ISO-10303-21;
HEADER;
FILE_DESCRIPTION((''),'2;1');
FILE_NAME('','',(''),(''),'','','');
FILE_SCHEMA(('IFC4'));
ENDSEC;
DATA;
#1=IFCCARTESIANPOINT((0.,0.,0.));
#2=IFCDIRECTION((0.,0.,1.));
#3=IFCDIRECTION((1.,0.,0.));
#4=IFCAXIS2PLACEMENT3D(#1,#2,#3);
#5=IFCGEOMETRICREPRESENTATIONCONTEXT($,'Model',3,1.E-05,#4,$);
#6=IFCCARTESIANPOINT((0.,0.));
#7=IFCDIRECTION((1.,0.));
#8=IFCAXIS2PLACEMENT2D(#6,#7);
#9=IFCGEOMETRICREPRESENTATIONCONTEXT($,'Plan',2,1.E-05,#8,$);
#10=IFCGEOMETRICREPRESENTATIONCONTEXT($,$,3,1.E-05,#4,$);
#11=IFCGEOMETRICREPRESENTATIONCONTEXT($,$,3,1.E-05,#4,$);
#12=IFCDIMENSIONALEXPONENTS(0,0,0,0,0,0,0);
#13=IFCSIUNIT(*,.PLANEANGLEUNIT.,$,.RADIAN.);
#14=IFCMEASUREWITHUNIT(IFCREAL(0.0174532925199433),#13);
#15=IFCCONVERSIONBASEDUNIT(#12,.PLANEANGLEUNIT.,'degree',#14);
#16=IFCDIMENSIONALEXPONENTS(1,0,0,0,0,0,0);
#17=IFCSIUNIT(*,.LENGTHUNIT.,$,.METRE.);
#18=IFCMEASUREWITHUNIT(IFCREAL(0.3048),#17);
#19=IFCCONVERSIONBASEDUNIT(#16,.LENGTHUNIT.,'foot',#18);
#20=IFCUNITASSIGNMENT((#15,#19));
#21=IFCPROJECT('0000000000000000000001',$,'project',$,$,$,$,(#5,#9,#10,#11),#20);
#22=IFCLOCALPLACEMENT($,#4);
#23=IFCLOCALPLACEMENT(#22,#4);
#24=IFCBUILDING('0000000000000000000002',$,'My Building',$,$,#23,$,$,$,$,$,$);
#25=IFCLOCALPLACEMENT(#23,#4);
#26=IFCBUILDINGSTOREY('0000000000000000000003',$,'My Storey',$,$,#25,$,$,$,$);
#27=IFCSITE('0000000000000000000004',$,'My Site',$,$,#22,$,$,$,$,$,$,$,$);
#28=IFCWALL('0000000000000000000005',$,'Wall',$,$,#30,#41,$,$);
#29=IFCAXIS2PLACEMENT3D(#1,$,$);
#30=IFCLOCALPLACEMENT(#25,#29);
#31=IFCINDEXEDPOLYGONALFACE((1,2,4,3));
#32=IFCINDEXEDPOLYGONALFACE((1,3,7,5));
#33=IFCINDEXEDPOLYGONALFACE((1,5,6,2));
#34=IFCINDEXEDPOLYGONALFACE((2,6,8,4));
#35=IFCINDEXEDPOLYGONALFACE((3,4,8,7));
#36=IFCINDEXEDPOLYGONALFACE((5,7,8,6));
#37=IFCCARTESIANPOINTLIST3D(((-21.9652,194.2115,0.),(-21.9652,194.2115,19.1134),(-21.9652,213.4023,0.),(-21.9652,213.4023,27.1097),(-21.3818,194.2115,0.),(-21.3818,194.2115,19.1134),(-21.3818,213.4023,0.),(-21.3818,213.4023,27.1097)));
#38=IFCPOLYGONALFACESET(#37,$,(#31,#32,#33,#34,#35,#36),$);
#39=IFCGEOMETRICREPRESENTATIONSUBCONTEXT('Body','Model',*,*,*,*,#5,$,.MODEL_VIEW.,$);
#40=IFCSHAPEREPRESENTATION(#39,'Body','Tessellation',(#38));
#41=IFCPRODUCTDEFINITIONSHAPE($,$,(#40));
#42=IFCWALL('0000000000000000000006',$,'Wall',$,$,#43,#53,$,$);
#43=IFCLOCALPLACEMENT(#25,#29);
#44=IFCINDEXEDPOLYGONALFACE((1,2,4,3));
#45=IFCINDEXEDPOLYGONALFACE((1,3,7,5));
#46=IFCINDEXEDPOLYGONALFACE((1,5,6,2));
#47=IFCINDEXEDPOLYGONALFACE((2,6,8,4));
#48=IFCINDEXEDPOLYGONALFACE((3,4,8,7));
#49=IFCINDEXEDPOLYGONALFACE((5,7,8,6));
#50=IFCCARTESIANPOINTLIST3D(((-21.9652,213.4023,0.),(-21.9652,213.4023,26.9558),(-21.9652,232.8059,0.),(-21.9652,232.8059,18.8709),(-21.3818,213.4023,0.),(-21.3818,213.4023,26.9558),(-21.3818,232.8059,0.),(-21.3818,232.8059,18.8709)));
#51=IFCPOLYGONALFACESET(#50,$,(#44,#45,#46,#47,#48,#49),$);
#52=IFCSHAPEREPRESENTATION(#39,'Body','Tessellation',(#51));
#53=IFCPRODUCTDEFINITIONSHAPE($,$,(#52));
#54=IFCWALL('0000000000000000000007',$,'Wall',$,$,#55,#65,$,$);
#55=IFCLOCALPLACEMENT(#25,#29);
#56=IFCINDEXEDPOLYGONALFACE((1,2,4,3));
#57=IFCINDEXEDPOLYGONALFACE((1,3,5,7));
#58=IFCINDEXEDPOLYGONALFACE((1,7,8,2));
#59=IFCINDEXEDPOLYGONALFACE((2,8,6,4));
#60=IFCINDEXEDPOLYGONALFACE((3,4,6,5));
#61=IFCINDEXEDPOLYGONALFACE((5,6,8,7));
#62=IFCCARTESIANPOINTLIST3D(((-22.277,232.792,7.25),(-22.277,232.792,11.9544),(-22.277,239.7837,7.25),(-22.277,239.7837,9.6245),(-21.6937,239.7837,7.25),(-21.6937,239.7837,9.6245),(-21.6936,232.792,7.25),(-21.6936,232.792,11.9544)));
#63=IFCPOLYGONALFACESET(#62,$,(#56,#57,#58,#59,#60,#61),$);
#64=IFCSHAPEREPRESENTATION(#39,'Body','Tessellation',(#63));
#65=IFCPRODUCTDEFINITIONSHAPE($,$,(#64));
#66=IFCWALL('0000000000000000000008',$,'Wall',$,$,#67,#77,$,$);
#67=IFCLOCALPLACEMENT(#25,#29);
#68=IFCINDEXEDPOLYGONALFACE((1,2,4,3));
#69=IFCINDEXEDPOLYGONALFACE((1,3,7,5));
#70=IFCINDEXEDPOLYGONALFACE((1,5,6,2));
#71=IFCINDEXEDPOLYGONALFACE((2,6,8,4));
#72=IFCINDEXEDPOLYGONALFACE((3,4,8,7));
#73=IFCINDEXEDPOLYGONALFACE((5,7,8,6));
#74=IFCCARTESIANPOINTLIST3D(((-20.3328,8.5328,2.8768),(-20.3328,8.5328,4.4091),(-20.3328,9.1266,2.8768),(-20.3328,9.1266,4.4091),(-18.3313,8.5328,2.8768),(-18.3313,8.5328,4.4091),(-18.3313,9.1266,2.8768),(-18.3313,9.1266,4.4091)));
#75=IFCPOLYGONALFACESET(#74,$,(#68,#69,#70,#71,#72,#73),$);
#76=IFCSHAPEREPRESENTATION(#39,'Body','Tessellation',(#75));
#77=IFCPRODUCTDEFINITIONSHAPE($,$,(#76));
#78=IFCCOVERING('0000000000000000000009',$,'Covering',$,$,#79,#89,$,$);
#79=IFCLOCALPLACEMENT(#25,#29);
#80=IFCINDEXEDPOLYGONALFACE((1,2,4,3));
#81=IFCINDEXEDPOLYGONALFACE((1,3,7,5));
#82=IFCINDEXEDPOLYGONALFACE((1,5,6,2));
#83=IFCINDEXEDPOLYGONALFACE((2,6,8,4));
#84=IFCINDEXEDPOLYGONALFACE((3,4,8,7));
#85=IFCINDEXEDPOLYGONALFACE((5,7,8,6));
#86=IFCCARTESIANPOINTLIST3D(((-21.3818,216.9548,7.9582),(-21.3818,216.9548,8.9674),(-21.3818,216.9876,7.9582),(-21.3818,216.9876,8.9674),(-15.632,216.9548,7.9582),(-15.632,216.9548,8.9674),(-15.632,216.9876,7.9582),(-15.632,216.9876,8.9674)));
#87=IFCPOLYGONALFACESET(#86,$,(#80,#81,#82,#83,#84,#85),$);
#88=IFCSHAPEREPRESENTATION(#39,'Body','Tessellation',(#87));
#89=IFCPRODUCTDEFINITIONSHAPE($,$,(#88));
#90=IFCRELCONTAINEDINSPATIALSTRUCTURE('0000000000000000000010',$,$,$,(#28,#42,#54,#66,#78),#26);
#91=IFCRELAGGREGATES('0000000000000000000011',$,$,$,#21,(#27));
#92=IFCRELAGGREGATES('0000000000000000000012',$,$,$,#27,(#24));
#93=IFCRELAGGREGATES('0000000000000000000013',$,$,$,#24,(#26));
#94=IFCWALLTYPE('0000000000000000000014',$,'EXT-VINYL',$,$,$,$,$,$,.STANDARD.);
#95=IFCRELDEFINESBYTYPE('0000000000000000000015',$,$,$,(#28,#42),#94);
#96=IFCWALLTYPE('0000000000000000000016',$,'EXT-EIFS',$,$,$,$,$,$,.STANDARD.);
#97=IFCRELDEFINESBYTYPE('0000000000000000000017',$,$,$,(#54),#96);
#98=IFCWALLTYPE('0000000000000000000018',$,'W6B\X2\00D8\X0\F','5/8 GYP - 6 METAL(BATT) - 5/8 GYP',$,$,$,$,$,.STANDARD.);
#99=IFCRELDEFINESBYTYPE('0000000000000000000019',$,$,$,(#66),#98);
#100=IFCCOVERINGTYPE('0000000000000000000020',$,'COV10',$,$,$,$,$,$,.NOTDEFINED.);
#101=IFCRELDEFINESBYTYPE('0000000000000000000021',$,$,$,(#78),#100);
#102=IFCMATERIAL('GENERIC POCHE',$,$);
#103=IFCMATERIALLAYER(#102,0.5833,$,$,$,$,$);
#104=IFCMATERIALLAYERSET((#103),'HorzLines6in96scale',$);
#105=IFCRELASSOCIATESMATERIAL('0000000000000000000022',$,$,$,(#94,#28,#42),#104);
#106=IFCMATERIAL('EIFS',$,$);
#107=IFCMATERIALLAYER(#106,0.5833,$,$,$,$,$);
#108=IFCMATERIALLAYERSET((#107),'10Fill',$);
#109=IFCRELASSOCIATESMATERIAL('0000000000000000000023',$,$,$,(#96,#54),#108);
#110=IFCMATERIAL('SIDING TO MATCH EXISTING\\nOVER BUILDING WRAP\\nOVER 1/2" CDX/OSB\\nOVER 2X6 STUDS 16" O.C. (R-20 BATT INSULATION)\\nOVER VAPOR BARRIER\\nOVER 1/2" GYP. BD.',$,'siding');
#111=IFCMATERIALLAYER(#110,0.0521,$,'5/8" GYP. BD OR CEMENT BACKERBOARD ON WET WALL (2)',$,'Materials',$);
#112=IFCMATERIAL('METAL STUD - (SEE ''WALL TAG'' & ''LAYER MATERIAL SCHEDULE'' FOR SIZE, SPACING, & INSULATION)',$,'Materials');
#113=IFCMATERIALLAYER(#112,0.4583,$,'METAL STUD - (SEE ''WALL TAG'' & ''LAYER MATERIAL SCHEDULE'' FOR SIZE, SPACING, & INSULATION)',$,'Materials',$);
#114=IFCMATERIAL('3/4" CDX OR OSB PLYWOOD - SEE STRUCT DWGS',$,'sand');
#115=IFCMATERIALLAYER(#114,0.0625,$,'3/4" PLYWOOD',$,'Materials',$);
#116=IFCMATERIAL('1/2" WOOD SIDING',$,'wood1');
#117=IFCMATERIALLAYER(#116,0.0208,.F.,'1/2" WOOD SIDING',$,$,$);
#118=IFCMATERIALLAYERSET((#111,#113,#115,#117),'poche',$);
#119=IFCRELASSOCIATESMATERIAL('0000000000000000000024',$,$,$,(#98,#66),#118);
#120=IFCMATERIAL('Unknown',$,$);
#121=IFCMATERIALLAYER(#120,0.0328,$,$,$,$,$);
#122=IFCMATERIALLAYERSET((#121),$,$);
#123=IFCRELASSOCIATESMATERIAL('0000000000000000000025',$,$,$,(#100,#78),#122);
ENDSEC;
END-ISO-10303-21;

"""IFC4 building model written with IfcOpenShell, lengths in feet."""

from ifc_helpers import new_model, entity, si_unit, converted_unit, frame, origin_with_axes, origin_2d_with_axis, place, context, subcontext, project, spatial, indexed_curve, outline, extrude, clip, halfspace, material, layer, layer_set, layer_usage, type_object, element, save


model = new_model("IFC4")

# Units and contexts
model_context = context("Model", 3, precision=1e-05, world=origin_with_axes())
plan_context = context("Plan", 2, precision=1e-05, world=origin_2d_with_axis())
context_of_model_1 = context(None, 3, precision=1e-05, world=origin_with_axes())
context_of_model_2 = context(None, 3, precision=1e-05, world=origin_with_axes())
body_context = subcontext(model_context, "Body", "Model", "MODEL_VIEW")
ifc_project = project(units=[converted_unit("PLANEANGLEUNIT", "degree", entity("IfcReal", 0.0174532925199433), si_unit("PLANEANGLEUNIT", "RADIAN"), dimensions=[0, 0, 0, 0, 0, 0, 0]), converted_unit("LENGTHUNIT", "foot", entity("IfcReal", 0.3048), si_unit("LENGTHUNIT", "METRE"), dimensions=[1, 0, 0, 0, 0, 0, 0])], contexts=[model_context, plan_context, context_of_model_1, context_of_model_2])

# Site, building, storey
site_placement = place(None, origin_with_axes())
site = spatial("IfcSite", under=ifc_project, at=site_placement, Name="My Site")
building_placement = place(site_placement, origin_with_axes())
building = spatial("IfcBuilding", under=site, at=building_placement, Name="My Building")
storey_placement = place(building_placement, origin_with_axes())
storey = spatial("IfcBuildingStorey", under=building, at=storey_placement, Name="My Storey")

# Walls
ifc_material_1 = material(Name="GENERIC POCHE")
ifc_layer_1 = layer(ifc_material_1, 0.5833)
ifc_layer_set_1 = layer_set([ifc_layer_1], Name="HorzLines6in96scale")
ifc_layer_usage_1 = layer_usage(ifc_layer_set_1, "AXIS2", "POSITIVE", 0.0)
wall_type_1 = type_object("IfcWallType", Name="EXT-VINYL", PredefinedType="STANDARD", material=ifc_layer_set_1)
wall_1_placement = place(storey_placement, frame((-21.3818, 194.2115, 0.0), z_axis=(0.0, 0.0, 1.0), x_axis=(0.0, 1.0, 0.0)))
element("IfcWall", 1, at=wall_1_placement, inside=storey, type_object=wall_type_1, material=ifc_layer_usage_1, Name="Wall", context=body_context, shape_type="Clipping", body=[
    clip(extrude(outline(indexed_curve([(0.0, 0.0), (0.0, 0.5833), (19.1908, 0.5833), (19.1908, 0.0), (0.0, 0.0)], self_intersect=False)), origin_with_axes(), (0.0, 0.0, 1.0), 27.1097), halfspace(frame((19.1908, 0.0, 27.1097), z_axis=(-0.384618, 0.0, 0.923076), x_axis=(0.0, -1.0, 0.0)), False)),
])
ifc_layer_usage_2 = layer_usage(ifc_layer_set_1, "AXIS2", "POSITIVE", 0.0)
wall_2_placement = place(storey_placement, frame((-21.3818, 213.4023, 0.0), z_axis=(0.0, 0.0, 1.0), x_axis=(0.0, 1.0, 0.0)))
element("IfcWall", 2, at=wall_2_placement, inside=storey, type_object=wall_type_1, material=ifc_layer_usage_2, Name="Wall", context=body_context, shape_type="Clipping", body=[
    clip(extrude(outline(indexed_curve([(0.0, 0.0), (0.0, 0.5833), (19.4036, 0.5833), (19.4036, 0.0), (0.0, 0.0)], self_intersect=False)), origin_with_axes(), (0.0, 0.0, 1.0), 26.9558), halfspace(frame((0.0, 0.0, 26.9558), z_axis=(0.384618, 0.0, 0.923076), x_axis=(-0.000001, 1.0, 0.0)), False)),
])
ifc_material_2 = material(Name="EIFS")
ifc_layer_2 = layer(ifc_material_2, 0.5833)
ifc_layer_set_2 = layer_set([ifc_layer_2], Name="10Fill")
ifc_layer_usage_3 = layer_usage(ifc_layer_set_2, "AXIS2", "POSITIVE", 0.0)
wall_type_2 = type_object("IfcWallType", Name="EXT-EIFS", PredefinedType="STANDARD", material=ifc_layer_set_2)
wall_3_placement = place(storey_placement, frame((-22.277, 239.7837, 7.25), z_axis=(0.0, 0.0, 1.0), x_axis=(0.000001, -1.0, 0.0)))
element("IfcWall", 3, at=wall_3_placement, inside=storey, type_object=wall_type_2, material=ifc_layer_usage_3, Name="Wall", context=body_context, shape_type="Clipping", body=[
    clip(extrude(outline(indexed_curve([(0.0, 0.0), (0.0, 0.5833), (6.9917, 0.5833), (6.9917, 0.0), (0.0, 0.0)], self_intersect=False)), origin_with_axes(), (0.0, 0.0, 1.0), 11.9544), halfspace(frame((6.9917, 0.0, 4.7044), z_axis=(-0.316146, 0.0, 0.948711), x_axis=(0.0, -1.0, 0.0)), False)),
])
ifc_material_3 = material(Name="SIDING TO MATCH EXISTING\\nOVER BUILDING WRAP\\nOVER 1/2\" CDX/OSB\\nOVER 2X6 STUDS 16\" O.C. (R-20 BATT INSULATION)\\nOVER VAPOR BARRIER\\nOVER 1/2\" GYP. BD.", Category="siding")
ifc_layer_3 = layer(ifc_material_3, 0.0521, Name="5/8\" GYP. BD OR CEMENT BACKERBOARD ON WET WALL (2)", Category="Materials")
ifc_material_4 = material(Name="METAL STUD - (SEE 'WALL TAG' & 'LAYER MATERIAL SCHEDULE' FOR SIZE, SPACING, & INSULATION)", Category="Materials")
ifc_layer_4 = layer(ifc_material_4, 0.4583, Name="METAL STUD - (SEE 'WALL TAG' & 'LAYER MATERIAL SCHEDULE' FOR SIZE, SPACING, & INSULATION)", Category="Materials")
ifc_material_5 = material(Name="3/4\" CDX OR OSB PLYWOOD - SEE STRUCT DWGS", Category="sand")
ifc_layer_5 = layer(ifc_material_5, 0.0625, Name="3/4\" PLYWOOD", Category="Materials")
ifc_material_6 = material(Name="1/2\" WOOD SIDING", Category="wood1")
ifc_layer_6 = layer(ifc_material_6, 0.0208, ventilated=False, Name="1/2\" WOOD SIDING")
ifc_layer_set_3 = layer_set([ifc_layer_3, ifc_layer_4, ifc_layer_5, ifc_layer_6], Name="poche")
ifc_layer_usage_4 = layer_usage(ifc_layer_set_3, "AXIS2", "POSITIVE", 0.0)
wall_type_3 = type_object("IfcWallType", Name="W6BØF", Description="5/8 GYP - 6 METAL(BATT) - 5/8 GYP", PredefinedType="STANDARD", material=ifc_layer_set_3)
wall_4_placement = place(storey_placement, frame((-20.3328, 8.5328, 2.8768), z_axis=(0.0, 0.0, 1.0), x_axis=(1.0, 0.0, 0.0)))
element("IfcWall", 4, at=wall_4_placement, inside=storey, type_object=wall_type_3, material=ifc_layer_usage_4, Name="Wall", context=body_context, shape_type="SweptSolid", body=[
    extrude(outline(indexed_curve([(0.0, 0.0), (0.0, 0.5937), (2.0015, 0.5937), (2.0015, 0.0), (0.0, 0.0)], self_intersect=False)), origin_with_axes(), (0.0, 0.0, 1.0), 1.5323),
])

# Covering
ifc_material_7 = material(Name="Unknown")
ifc_layer_7 = layer(ifc_material_7, 0.0328)
ifc_layer_set_4 = layer_set([ifc_layer_7])
ifc_layer_usage_5 = layer_usage(ifc_layer_set_4, "AXIS2", "POSITIVE", 0.0)
covering_type = type_object("IfcCoveringType", Name="COV10", PredefinedType="NOTDEFINED", material=ifc_layer_set_4)
covering_placement = place(storey_placement, frame((-21.3818, 216.9548, 7.9582), z_axis=(0.0, 0.0, 1.0), x_axis=(1.0, 0.0, 0.0)))
element("IfcCovering", 5, at=covering_placement, inside=storey, type_object=covering_type, material=ifc_layer_usage_5, Name="Covering", context=body_context, shape_type="SweptSolid", body=[
    extrude(outline(indexed_curve([(0.0, 0.0), (0.0, 0.0328), (5.7498, 0.0328), (5.7498, 0.0), (0.0, 0.0)], self_intersect=False)), origin_with_axes(), (0.0, 0.0, 1.0), 1.0092),
])

save(model, "model.ifc")
